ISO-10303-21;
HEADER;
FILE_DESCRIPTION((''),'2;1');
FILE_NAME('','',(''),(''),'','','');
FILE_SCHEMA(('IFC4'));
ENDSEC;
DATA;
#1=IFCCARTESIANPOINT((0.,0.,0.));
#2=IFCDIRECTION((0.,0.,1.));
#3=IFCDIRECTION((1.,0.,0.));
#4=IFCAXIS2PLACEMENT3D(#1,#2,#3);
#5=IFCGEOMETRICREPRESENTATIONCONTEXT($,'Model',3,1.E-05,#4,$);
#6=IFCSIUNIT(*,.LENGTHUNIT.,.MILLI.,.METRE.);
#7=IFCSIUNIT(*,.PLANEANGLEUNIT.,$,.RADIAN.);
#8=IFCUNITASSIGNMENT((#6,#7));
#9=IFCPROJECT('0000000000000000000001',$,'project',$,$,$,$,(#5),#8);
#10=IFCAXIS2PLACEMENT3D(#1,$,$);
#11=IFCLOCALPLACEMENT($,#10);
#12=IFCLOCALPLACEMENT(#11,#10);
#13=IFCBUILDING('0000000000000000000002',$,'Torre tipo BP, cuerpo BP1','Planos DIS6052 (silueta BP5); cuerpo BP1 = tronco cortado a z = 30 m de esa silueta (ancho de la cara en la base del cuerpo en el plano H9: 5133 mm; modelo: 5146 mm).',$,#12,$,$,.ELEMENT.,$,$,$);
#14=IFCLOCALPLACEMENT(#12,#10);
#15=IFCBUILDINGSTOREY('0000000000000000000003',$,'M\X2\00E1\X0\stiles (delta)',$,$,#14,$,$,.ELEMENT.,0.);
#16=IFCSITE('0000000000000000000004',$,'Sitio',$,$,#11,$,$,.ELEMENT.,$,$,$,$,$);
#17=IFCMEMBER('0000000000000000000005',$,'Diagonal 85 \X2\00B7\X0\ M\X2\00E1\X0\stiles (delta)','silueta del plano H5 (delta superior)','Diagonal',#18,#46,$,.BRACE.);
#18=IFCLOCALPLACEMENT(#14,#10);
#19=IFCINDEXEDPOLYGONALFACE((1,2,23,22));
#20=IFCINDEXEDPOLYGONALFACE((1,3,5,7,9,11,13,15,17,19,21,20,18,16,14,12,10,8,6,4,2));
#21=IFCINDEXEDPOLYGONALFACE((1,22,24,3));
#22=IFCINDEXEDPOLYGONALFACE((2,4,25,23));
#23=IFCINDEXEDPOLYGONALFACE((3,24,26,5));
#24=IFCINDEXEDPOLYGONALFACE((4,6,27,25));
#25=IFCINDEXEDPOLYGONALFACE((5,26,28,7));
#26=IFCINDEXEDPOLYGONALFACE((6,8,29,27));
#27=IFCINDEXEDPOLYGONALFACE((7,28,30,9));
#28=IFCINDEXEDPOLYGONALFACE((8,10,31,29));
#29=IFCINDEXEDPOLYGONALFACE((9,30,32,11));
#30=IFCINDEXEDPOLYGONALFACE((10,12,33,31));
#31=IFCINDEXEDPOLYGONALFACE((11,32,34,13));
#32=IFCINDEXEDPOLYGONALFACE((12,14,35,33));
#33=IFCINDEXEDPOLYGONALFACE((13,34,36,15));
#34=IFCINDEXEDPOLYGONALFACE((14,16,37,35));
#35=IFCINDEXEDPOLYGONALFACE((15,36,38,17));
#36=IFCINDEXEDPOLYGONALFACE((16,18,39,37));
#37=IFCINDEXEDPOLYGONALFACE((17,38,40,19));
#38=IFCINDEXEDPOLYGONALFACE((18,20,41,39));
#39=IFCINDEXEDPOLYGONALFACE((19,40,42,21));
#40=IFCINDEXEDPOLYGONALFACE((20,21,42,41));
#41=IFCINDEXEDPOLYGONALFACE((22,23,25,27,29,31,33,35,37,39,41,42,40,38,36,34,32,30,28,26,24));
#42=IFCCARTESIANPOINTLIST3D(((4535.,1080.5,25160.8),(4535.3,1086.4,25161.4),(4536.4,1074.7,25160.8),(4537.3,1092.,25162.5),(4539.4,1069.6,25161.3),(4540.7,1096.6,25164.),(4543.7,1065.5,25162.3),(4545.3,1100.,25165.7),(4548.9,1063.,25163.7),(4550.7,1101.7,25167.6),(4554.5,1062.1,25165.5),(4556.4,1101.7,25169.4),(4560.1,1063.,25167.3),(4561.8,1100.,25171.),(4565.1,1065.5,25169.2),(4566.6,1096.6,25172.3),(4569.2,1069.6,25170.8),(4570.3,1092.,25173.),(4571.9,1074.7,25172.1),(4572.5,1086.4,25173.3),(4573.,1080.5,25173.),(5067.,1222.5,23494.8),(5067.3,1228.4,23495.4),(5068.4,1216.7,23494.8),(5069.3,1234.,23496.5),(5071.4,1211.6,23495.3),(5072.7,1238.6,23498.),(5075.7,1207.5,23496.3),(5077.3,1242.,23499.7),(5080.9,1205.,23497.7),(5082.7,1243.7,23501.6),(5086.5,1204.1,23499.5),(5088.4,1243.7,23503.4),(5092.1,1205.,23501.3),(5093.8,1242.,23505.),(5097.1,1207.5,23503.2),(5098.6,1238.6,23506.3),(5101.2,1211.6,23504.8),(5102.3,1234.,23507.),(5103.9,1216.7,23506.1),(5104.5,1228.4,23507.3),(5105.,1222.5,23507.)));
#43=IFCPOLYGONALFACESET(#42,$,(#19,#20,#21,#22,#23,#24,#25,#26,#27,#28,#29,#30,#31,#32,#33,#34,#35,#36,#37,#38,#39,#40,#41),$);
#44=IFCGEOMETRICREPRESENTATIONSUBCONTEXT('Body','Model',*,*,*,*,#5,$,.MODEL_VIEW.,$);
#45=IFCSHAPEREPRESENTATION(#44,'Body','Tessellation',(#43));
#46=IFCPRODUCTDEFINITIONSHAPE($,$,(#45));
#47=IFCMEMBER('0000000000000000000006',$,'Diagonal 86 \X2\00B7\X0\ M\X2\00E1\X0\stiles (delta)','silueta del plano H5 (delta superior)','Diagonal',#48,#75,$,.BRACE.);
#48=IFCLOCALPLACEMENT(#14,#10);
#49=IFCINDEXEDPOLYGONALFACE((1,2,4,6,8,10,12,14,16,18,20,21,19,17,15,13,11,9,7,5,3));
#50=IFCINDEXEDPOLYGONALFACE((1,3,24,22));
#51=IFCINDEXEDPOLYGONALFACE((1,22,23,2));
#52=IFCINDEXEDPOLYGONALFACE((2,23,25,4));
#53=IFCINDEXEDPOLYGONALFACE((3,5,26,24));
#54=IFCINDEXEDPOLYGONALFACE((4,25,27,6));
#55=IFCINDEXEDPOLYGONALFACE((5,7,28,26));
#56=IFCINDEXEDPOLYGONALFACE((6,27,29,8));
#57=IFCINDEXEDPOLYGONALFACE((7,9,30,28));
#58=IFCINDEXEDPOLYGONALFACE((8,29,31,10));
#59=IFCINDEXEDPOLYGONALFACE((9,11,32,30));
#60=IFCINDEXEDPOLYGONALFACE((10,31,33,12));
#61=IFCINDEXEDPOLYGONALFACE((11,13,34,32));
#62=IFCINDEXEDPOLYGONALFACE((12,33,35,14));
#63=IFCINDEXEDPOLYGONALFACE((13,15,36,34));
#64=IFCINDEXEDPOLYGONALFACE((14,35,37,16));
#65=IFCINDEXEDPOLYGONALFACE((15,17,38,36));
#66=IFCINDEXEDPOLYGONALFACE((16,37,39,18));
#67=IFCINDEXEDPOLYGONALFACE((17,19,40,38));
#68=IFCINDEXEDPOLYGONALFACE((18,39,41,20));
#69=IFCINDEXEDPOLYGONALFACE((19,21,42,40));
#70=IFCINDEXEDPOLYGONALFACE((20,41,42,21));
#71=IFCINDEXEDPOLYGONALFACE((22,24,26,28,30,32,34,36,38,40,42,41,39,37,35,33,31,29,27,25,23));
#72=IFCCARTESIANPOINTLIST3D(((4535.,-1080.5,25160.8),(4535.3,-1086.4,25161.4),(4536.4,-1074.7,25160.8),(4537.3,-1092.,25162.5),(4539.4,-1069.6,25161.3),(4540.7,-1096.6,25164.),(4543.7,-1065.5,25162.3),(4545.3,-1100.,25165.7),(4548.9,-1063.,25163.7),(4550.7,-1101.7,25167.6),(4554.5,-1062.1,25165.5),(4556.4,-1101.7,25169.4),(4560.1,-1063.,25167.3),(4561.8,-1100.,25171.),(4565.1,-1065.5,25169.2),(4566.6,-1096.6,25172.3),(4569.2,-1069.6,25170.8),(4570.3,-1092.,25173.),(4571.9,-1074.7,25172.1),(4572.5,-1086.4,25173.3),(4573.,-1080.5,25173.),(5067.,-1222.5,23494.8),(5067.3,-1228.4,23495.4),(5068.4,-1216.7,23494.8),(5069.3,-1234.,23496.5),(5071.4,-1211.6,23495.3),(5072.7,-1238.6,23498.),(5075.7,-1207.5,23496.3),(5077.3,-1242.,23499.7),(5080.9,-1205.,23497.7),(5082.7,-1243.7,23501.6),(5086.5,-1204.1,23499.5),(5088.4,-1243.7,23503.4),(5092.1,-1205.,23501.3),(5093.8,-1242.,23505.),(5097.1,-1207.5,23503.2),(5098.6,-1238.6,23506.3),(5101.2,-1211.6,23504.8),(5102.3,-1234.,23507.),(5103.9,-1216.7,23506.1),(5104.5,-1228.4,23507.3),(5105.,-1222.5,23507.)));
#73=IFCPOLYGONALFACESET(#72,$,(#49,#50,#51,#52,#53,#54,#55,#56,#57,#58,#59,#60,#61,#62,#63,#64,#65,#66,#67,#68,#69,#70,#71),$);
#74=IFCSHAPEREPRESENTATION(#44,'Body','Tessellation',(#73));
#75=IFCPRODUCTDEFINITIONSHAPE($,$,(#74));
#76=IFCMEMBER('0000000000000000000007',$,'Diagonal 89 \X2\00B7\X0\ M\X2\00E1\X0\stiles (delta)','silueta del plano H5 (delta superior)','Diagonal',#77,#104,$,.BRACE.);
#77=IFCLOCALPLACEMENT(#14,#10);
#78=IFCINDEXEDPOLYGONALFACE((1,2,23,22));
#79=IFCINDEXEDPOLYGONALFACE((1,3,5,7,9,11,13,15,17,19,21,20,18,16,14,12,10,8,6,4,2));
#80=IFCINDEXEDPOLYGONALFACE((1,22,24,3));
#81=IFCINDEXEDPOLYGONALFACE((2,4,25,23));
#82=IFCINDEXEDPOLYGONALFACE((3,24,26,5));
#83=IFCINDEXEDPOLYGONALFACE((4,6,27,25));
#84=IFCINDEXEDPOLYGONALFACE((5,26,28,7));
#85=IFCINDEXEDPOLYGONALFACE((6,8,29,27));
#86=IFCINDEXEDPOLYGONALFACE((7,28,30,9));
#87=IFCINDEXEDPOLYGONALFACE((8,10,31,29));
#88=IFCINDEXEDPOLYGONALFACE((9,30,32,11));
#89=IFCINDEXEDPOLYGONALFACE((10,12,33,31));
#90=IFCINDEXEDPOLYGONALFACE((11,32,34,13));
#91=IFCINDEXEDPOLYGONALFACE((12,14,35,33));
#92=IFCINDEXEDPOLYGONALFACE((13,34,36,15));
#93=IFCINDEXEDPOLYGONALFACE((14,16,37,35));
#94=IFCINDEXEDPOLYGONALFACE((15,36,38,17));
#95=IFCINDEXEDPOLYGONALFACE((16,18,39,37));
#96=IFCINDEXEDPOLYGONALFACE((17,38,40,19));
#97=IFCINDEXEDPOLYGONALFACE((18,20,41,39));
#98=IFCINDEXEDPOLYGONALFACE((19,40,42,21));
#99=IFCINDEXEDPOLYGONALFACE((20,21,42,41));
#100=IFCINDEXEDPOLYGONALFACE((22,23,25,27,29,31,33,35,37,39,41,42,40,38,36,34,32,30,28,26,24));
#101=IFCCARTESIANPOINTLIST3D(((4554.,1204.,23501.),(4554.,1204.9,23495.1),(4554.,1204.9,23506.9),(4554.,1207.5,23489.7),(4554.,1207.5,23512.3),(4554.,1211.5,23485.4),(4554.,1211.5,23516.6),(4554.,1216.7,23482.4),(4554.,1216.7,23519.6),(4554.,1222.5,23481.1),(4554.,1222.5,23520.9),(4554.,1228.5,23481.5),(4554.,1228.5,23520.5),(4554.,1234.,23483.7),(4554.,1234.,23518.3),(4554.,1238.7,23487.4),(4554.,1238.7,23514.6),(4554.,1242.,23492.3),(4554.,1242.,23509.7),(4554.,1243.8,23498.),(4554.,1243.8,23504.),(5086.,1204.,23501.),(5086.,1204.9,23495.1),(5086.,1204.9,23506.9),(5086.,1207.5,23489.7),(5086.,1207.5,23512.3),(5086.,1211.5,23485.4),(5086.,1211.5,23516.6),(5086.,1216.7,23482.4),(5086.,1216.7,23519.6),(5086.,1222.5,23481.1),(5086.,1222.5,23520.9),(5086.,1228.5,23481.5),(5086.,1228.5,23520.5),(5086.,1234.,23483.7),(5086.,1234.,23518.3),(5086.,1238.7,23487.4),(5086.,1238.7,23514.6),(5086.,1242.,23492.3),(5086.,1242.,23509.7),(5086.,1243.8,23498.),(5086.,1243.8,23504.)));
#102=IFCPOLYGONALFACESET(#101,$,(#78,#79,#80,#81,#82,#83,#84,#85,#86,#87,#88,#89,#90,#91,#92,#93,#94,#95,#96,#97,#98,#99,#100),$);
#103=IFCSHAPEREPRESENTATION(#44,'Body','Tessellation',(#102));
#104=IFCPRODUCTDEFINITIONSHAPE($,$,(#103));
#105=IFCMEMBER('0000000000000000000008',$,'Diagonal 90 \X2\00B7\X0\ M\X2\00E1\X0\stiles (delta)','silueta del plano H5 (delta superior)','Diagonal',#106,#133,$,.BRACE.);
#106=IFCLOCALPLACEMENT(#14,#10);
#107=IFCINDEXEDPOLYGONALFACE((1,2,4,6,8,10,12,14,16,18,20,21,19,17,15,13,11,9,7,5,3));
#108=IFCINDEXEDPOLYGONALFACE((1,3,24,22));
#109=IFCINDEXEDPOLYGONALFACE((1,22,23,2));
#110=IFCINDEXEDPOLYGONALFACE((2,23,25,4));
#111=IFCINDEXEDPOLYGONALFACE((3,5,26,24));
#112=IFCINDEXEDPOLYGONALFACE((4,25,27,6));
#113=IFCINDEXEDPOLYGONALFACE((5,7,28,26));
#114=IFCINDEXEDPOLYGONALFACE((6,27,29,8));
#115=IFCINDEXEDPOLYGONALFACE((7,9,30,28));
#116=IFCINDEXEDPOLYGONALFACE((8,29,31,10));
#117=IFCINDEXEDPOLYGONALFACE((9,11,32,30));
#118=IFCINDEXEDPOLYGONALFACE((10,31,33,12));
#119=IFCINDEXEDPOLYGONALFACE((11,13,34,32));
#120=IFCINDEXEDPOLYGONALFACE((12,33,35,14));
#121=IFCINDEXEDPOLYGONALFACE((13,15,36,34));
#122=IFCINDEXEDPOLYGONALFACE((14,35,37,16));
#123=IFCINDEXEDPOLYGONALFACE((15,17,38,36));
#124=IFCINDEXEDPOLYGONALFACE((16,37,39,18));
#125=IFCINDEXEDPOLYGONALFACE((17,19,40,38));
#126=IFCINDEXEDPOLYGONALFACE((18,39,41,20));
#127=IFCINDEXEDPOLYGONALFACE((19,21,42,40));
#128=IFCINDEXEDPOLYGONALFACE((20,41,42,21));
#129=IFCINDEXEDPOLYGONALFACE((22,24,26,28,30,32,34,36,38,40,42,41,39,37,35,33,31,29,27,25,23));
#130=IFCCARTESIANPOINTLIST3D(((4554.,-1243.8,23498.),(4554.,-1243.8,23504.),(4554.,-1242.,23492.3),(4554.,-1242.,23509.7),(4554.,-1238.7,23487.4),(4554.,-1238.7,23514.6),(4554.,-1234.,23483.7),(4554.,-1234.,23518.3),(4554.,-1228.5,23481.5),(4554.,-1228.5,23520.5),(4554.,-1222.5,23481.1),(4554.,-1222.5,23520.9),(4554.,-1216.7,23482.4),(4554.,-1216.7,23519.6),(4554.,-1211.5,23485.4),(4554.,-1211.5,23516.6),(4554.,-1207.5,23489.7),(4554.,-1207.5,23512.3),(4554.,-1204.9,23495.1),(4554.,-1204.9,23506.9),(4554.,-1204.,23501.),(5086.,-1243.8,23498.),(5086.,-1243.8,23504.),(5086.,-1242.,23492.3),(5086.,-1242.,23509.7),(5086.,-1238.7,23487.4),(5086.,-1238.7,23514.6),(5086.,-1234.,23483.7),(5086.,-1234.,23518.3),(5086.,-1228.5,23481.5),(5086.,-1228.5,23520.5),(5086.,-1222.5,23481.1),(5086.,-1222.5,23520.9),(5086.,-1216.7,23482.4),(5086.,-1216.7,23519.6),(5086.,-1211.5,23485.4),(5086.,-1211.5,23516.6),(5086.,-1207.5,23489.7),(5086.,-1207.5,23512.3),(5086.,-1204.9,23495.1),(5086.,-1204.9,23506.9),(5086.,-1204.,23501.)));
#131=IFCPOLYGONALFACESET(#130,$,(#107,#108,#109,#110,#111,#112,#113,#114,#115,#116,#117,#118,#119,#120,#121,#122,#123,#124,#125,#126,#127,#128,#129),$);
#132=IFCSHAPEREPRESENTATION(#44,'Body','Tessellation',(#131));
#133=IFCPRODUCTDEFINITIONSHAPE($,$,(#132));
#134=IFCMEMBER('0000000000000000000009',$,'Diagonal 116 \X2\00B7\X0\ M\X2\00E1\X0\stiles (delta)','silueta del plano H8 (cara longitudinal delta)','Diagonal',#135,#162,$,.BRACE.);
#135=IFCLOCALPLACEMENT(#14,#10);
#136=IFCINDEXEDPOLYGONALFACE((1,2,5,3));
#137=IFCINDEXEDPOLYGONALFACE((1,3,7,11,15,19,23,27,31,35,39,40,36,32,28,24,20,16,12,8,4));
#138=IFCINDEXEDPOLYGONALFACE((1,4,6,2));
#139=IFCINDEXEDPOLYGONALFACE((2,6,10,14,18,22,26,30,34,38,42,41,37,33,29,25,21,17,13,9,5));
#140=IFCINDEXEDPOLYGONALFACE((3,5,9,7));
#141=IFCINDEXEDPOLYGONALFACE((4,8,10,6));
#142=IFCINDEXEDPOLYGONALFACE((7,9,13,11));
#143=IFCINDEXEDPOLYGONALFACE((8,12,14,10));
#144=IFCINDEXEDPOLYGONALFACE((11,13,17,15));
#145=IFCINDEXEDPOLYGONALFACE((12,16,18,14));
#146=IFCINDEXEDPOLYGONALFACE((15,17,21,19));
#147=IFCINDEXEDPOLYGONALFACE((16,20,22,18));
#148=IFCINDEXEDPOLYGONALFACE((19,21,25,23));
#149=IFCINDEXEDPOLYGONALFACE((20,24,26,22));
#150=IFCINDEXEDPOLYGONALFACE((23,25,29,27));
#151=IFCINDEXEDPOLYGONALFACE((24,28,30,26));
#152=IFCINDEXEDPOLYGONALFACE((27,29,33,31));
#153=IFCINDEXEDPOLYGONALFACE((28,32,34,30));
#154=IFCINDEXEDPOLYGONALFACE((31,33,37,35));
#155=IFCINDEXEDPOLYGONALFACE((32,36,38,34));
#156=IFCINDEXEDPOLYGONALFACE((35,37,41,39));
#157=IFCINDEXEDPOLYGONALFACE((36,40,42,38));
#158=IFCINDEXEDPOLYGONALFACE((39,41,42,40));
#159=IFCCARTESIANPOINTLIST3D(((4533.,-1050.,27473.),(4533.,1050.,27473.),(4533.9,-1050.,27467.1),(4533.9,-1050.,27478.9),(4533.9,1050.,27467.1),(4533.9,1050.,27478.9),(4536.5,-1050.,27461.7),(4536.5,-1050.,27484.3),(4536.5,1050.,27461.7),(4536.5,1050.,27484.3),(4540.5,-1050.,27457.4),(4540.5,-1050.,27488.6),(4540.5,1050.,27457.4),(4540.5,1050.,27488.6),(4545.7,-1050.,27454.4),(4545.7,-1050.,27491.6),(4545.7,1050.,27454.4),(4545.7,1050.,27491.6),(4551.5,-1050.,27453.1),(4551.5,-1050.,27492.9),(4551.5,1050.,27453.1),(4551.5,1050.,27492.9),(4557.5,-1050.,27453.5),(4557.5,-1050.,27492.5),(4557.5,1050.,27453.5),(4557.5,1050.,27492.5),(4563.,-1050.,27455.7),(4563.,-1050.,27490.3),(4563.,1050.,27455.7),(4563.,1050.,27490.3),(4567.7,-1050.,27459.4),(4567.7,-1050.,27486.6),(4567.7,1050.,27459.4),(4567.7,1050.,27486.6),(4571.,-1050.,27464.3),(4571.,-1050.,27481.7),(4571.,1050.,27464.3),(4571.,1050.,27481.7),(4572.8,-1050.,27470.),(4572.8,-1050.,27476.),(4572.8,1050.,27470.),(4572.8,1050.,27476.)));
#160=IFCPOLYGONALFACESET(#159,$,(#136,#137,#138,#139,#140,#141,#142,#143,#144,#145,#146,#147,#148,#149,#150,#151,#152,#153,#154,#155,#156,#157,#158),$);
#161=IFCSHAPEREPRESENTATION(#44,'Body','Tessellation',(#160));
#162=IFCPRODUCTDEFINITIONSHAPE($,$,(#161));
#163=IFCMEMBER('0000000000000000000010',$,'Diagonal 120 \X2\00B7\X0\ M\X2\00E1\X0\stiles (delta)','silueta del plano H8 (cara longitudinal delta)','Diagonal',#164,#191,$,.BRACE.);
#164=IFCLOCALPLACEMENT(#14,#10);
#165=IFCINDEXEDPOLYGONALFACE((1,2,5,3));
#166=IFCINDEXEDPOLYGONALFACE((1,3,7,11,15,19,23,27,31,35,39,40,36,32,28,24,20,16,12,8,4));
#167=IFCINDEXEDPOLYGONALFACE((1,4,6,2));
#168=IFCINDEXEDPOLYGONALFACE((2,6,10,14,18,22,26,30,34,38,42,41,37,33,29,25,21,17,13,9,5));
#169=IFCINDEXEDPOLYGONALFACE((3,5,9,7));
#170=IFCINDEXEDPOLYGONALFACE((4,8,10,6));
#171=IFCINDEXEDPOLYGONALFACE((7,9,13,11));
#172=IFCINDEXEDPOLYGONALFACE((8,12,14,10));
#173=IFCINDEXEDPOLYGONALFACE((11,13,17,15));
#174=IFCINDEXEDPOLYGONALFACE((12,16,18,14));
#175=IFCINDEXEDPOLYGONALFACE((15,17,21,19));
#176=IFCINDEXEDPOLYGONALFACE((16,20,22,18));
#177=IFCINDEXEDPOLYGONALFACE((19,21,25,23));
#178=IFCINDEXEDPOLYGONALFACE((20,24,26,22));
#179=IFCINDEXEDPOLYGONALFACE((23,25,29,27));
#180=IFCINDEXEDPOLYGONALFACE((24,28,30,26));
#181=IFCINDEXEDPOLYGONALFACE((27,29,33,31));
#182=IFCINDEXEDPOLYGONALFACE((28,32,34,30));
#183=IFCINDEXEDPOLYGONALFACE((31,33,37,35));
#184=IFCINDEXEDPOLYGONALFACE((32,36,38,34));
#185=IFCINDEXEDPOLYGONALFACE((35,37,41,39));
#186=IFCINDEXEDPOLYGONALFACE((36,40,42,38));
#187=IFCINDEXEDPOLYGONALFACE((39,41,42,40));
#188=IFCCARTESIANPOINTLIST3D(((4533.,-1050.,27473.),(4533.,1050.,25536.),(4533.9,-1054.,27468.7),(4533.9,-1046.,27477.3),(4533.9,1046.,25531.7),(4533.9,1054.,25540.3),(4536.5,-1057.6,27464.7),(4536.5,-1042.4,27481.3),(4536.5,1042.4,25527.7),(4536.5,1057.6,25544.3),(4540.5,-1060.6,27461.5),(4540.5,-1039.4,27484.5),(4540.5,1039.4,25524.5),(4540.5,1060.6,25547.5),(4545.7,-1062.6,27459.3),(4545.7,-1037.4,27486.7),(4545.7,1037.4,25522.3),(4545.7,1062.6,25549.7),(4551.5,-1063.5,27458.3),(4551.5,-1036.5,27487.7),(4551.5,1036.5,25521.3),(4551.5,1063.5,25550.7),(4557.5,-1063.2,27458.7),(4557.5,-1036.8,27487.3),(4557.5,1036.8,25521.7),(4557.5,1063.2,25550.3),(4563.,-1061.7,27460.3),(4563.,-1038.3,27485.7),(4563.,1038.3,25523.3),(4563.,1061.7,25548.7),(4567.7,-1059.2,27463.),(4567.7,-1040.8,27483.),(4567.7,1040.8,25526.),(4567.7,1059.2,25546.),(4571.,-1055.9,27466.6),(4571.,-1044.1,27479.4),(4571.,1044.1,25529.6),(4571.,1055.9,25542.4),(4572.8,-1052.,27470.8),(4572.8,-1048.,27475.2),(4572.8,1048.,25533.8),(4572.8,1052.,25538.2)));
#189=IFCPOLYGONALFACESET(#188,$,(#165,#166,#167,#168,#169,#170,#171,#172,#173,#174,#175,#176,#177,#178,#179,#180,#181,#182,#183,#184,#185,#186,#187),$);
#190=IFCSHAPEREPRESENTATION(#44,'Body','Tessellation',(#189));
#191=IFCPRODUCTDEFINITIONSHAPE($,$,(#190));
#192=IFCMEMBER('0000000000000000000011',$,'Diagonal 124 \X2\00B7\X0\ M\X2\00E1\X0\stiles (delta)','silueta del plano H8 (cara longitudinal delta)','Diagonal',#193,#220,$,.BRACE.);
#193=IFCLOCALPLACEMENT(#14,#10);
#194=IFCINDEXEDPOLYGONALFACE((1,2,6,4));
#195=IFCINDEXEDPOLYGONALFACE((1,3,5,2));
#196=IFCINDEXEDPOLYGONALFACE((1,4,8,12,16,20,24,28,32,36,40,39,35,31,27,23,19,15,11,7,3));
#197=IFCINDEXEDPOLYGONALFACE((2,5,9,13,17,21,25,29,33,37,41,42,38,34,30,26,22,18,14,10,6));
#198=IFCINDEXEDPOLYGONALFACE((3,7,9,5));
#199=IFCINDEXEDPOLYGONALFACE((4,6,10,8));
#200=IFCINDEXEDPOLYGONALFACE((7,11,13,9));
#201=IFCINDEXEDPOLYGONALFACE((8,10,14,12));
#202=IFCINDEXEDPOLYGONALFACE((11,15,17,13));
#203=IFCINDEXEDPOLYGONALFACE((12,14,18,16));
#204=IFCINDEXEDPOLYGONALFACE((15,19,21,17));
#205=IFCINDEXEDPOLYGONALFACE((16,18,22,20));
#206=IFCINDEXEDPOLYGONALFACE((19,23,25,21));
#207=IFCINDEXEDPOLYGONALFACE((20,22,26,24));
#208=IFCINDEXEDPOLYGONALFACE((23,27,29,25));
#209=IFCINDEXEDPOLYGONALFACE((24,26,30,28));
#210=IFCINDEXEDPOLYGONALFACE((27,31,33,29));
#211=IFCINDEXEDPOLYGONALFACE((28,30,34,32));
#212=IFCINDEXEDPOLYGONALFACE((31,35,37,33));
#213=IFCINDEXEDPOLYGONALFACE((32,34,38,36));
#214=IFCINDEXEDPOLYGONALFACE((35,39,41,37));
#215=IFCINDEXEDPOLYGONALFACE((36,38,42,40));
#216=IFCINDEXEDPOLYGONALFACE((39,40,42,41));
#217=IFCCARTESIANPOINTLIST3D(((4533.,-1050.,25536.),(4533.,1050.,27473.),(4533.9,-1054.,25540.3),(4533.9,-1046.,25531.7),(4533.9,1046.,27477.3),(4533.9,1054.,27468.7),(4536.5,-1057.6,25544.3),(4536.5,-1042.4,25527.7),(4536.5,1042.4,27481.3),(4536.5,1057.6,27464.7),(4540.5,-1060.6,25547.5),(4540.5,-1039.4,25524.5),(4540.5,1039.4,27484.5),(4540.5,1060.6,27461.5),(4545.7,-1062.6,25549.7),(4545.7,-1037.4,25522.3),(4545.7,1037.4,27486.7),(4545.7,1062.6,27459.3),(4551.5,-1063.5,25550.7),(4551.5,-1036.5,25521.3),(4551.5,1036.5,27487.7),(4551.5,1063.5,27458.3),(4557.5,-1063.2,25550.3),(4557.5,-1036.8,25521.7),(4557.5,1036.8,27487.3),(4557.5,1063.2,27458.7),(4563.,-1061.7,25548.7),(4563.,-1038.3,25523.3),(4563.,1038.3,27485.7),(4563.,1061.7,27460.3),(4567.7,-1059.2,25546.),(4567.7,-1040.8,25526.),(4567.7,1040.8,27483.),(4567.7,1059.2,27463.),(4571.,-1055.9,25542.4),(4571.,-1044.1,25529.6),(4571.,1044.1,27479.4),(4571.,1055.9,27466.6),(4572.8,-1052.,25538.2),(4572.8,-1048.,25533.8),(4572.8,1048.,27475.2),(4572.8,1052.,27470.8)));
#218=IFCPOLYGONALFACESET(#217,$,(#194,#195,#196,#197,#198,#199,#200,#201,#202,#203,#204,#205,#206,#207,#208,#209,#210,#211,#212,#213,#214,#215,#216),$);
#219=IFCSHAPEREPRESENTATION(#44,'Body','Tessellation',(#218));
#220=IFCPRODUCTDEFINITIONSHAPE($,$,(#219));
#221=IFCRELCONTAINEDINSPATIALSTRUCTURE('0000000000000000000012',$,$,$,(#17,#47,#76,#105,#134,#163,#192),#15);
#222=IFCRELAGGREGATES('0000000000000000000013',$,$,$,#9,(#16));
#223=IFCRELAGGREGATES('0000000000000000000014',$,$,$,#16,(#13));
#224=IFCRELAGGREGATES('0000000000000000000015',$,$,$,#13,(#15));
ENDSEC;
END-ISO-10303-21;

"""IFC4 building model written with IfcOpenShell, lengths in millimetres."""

from ifc_helpers import new_model, si_unit, frame, origin, origin_with_axes, place, context, subcontext, project, spatial, circle, extrude, element, save


model = new_model("IFC4")

# Units and contexts
model_context = context("Model", 3, precision=1e-05, world=origin_with_axes())
body_context = subcontext(model_context, "Body", "Model", "MODEL_VIEW")
ifc_project = project(units=[si_unit("LENGTHUNIT", "METRE", prefix="MILLI"), si_unit("PLANEANGLEUNIT", "RADIAN")], contexts=[model_context])

# Site, building, storey
site_placement = place(None, origin())
site = spatial("IfcSite", under=ifc_project, at=site_placement, Name="Sitio", CompositionType="ELEMENT")
building_placement = place(site_placement, origin())
building = spatial("IfcBuilding", under=site, at=building_placement, Name="Torre tipo BP, cuerpo BP1", Description="Planos DIS6052 (silueta BP5); cuerpo BP1 = tronco cortado a z = 30 m de esa silueta (ancho de la cara en la base del cuerpo en el plano H9: 5133 mm; modelo: 5146 mm).", CompositionType="ELEMENT")
storey_placement = place(building_placement, origin())
storey = spatial("IfcBuildingStorey", under=building, at=storey_placement, Name="Mástiles (delta)", CompositionType="ELEMENT", Elevation=0.0)

# Members
for number, where, z_axis, x_axis, name in (
    (1, (4554.0, 1082.0, 25167.0), (0.303197, 0.080929, -0.949485), (0.024618, -0.99672, -0.077093), "Diagonal 85 · Mástiles (delta)"),
    (2, (4554.0, -1082.0, 25167.0), (0.303197, -0.080929, -0.949485), (0.024618, 0.99672, -0.077093), "Diagonal 86 · Mástiles (delta)"),
):
    element("IfcMember", number, at=place(storey_placement, frame(where, z_axis=z_axis, x_axis=x_axis)), inside=storey, Name=name, Description="silueta del plano H5 (delta superior)", ObjectType="Diagonal", PredefinedType="BRACE", context=body_context, shape_type="SweptSolid", body=[
        extrude(circle(Radius=20.0), None, (0.0, 0.0, 1.0), 1754.6),
    ])
for number, where, z_axis, x_axis, name in (
    (3, (4554.0, 1224.0, 23501.0), (1.0, 0.0, 0.0), (0.0, -1.0, 0.0), "Diagonal 89 · Mástiles (delta)"),
    (4, (4554.0, -1224.0, 23501.0), (1.0, 0.0, 0.0), (0.0, 1.0, 0.0), "Diagonal 90 · Mástiles (delta)"),
):
    element("IfcMember", number, at=place(storey_placement, frame(where, z_axis=z_axis, x_axis=x_axis)), inside=storey, Name=name, Description="silueta del plano H5 (delta superior)", ObjectType="Diagonal", PredefinedType="BRACE", context=body_context, shape_type="SweptSolid", body=[
        extrude(circle(Radius=20.0), None, (0.0, 0.0, 1.0), 532.0),
    ])
member_1_placement = place(storey_placement, frame((4553.0, -1050.0, 27473.0), z_axis=(0.0, 1.0, 0.0), x_axis=(-1.0, 0.0, 0.0)))
element("IfcMember", 5, at=member_1_placement, inside=storey, Name="Diagonal 116 · Mástiles (delta)", Description="silueta del plano H8 (cara longitudinal delta)", ObjectType="Diagonal", PredefinedType="BRACE", context=body_context, shape_type="SweptSolid", body=[
    extrude(circle(Radius=20.0), None, (0.0, 0.0, 1.0), 2100.0),
])
for number, where, z_axis, x_axis, name in (
    (6, (4553.0, -1050.0, 27473.0), (0.0, 0.735058, -0.678004), (-1.0, 0.0, 0.0), "Diagonal 120 · Mástiles (delta)"),
    (7, (4553.0, 1050.0, 27473.0), (0.0, -0.735058, -0.678004), (-1.0, 0.0, 0.0), "Diagonal 124 · Mástiles (delta)"),
):
    element("IfcMember", number, at=place(storey_placement, frame(where, z_axis=z_axis, x_axis=x_axis)), inside=storey, Name=name, Description="silueta del plano H8 (cara longitudinal delta)", ObjectType="Diagonal", PredefinedType="BRACE", context=body_context, shape_type="SweptSolid", body=[
        extrude(circle(Radius=20.0), None, (0.0, 0.0, 1.0), 2856.9),
    ])

save(model, "model.ifc")
